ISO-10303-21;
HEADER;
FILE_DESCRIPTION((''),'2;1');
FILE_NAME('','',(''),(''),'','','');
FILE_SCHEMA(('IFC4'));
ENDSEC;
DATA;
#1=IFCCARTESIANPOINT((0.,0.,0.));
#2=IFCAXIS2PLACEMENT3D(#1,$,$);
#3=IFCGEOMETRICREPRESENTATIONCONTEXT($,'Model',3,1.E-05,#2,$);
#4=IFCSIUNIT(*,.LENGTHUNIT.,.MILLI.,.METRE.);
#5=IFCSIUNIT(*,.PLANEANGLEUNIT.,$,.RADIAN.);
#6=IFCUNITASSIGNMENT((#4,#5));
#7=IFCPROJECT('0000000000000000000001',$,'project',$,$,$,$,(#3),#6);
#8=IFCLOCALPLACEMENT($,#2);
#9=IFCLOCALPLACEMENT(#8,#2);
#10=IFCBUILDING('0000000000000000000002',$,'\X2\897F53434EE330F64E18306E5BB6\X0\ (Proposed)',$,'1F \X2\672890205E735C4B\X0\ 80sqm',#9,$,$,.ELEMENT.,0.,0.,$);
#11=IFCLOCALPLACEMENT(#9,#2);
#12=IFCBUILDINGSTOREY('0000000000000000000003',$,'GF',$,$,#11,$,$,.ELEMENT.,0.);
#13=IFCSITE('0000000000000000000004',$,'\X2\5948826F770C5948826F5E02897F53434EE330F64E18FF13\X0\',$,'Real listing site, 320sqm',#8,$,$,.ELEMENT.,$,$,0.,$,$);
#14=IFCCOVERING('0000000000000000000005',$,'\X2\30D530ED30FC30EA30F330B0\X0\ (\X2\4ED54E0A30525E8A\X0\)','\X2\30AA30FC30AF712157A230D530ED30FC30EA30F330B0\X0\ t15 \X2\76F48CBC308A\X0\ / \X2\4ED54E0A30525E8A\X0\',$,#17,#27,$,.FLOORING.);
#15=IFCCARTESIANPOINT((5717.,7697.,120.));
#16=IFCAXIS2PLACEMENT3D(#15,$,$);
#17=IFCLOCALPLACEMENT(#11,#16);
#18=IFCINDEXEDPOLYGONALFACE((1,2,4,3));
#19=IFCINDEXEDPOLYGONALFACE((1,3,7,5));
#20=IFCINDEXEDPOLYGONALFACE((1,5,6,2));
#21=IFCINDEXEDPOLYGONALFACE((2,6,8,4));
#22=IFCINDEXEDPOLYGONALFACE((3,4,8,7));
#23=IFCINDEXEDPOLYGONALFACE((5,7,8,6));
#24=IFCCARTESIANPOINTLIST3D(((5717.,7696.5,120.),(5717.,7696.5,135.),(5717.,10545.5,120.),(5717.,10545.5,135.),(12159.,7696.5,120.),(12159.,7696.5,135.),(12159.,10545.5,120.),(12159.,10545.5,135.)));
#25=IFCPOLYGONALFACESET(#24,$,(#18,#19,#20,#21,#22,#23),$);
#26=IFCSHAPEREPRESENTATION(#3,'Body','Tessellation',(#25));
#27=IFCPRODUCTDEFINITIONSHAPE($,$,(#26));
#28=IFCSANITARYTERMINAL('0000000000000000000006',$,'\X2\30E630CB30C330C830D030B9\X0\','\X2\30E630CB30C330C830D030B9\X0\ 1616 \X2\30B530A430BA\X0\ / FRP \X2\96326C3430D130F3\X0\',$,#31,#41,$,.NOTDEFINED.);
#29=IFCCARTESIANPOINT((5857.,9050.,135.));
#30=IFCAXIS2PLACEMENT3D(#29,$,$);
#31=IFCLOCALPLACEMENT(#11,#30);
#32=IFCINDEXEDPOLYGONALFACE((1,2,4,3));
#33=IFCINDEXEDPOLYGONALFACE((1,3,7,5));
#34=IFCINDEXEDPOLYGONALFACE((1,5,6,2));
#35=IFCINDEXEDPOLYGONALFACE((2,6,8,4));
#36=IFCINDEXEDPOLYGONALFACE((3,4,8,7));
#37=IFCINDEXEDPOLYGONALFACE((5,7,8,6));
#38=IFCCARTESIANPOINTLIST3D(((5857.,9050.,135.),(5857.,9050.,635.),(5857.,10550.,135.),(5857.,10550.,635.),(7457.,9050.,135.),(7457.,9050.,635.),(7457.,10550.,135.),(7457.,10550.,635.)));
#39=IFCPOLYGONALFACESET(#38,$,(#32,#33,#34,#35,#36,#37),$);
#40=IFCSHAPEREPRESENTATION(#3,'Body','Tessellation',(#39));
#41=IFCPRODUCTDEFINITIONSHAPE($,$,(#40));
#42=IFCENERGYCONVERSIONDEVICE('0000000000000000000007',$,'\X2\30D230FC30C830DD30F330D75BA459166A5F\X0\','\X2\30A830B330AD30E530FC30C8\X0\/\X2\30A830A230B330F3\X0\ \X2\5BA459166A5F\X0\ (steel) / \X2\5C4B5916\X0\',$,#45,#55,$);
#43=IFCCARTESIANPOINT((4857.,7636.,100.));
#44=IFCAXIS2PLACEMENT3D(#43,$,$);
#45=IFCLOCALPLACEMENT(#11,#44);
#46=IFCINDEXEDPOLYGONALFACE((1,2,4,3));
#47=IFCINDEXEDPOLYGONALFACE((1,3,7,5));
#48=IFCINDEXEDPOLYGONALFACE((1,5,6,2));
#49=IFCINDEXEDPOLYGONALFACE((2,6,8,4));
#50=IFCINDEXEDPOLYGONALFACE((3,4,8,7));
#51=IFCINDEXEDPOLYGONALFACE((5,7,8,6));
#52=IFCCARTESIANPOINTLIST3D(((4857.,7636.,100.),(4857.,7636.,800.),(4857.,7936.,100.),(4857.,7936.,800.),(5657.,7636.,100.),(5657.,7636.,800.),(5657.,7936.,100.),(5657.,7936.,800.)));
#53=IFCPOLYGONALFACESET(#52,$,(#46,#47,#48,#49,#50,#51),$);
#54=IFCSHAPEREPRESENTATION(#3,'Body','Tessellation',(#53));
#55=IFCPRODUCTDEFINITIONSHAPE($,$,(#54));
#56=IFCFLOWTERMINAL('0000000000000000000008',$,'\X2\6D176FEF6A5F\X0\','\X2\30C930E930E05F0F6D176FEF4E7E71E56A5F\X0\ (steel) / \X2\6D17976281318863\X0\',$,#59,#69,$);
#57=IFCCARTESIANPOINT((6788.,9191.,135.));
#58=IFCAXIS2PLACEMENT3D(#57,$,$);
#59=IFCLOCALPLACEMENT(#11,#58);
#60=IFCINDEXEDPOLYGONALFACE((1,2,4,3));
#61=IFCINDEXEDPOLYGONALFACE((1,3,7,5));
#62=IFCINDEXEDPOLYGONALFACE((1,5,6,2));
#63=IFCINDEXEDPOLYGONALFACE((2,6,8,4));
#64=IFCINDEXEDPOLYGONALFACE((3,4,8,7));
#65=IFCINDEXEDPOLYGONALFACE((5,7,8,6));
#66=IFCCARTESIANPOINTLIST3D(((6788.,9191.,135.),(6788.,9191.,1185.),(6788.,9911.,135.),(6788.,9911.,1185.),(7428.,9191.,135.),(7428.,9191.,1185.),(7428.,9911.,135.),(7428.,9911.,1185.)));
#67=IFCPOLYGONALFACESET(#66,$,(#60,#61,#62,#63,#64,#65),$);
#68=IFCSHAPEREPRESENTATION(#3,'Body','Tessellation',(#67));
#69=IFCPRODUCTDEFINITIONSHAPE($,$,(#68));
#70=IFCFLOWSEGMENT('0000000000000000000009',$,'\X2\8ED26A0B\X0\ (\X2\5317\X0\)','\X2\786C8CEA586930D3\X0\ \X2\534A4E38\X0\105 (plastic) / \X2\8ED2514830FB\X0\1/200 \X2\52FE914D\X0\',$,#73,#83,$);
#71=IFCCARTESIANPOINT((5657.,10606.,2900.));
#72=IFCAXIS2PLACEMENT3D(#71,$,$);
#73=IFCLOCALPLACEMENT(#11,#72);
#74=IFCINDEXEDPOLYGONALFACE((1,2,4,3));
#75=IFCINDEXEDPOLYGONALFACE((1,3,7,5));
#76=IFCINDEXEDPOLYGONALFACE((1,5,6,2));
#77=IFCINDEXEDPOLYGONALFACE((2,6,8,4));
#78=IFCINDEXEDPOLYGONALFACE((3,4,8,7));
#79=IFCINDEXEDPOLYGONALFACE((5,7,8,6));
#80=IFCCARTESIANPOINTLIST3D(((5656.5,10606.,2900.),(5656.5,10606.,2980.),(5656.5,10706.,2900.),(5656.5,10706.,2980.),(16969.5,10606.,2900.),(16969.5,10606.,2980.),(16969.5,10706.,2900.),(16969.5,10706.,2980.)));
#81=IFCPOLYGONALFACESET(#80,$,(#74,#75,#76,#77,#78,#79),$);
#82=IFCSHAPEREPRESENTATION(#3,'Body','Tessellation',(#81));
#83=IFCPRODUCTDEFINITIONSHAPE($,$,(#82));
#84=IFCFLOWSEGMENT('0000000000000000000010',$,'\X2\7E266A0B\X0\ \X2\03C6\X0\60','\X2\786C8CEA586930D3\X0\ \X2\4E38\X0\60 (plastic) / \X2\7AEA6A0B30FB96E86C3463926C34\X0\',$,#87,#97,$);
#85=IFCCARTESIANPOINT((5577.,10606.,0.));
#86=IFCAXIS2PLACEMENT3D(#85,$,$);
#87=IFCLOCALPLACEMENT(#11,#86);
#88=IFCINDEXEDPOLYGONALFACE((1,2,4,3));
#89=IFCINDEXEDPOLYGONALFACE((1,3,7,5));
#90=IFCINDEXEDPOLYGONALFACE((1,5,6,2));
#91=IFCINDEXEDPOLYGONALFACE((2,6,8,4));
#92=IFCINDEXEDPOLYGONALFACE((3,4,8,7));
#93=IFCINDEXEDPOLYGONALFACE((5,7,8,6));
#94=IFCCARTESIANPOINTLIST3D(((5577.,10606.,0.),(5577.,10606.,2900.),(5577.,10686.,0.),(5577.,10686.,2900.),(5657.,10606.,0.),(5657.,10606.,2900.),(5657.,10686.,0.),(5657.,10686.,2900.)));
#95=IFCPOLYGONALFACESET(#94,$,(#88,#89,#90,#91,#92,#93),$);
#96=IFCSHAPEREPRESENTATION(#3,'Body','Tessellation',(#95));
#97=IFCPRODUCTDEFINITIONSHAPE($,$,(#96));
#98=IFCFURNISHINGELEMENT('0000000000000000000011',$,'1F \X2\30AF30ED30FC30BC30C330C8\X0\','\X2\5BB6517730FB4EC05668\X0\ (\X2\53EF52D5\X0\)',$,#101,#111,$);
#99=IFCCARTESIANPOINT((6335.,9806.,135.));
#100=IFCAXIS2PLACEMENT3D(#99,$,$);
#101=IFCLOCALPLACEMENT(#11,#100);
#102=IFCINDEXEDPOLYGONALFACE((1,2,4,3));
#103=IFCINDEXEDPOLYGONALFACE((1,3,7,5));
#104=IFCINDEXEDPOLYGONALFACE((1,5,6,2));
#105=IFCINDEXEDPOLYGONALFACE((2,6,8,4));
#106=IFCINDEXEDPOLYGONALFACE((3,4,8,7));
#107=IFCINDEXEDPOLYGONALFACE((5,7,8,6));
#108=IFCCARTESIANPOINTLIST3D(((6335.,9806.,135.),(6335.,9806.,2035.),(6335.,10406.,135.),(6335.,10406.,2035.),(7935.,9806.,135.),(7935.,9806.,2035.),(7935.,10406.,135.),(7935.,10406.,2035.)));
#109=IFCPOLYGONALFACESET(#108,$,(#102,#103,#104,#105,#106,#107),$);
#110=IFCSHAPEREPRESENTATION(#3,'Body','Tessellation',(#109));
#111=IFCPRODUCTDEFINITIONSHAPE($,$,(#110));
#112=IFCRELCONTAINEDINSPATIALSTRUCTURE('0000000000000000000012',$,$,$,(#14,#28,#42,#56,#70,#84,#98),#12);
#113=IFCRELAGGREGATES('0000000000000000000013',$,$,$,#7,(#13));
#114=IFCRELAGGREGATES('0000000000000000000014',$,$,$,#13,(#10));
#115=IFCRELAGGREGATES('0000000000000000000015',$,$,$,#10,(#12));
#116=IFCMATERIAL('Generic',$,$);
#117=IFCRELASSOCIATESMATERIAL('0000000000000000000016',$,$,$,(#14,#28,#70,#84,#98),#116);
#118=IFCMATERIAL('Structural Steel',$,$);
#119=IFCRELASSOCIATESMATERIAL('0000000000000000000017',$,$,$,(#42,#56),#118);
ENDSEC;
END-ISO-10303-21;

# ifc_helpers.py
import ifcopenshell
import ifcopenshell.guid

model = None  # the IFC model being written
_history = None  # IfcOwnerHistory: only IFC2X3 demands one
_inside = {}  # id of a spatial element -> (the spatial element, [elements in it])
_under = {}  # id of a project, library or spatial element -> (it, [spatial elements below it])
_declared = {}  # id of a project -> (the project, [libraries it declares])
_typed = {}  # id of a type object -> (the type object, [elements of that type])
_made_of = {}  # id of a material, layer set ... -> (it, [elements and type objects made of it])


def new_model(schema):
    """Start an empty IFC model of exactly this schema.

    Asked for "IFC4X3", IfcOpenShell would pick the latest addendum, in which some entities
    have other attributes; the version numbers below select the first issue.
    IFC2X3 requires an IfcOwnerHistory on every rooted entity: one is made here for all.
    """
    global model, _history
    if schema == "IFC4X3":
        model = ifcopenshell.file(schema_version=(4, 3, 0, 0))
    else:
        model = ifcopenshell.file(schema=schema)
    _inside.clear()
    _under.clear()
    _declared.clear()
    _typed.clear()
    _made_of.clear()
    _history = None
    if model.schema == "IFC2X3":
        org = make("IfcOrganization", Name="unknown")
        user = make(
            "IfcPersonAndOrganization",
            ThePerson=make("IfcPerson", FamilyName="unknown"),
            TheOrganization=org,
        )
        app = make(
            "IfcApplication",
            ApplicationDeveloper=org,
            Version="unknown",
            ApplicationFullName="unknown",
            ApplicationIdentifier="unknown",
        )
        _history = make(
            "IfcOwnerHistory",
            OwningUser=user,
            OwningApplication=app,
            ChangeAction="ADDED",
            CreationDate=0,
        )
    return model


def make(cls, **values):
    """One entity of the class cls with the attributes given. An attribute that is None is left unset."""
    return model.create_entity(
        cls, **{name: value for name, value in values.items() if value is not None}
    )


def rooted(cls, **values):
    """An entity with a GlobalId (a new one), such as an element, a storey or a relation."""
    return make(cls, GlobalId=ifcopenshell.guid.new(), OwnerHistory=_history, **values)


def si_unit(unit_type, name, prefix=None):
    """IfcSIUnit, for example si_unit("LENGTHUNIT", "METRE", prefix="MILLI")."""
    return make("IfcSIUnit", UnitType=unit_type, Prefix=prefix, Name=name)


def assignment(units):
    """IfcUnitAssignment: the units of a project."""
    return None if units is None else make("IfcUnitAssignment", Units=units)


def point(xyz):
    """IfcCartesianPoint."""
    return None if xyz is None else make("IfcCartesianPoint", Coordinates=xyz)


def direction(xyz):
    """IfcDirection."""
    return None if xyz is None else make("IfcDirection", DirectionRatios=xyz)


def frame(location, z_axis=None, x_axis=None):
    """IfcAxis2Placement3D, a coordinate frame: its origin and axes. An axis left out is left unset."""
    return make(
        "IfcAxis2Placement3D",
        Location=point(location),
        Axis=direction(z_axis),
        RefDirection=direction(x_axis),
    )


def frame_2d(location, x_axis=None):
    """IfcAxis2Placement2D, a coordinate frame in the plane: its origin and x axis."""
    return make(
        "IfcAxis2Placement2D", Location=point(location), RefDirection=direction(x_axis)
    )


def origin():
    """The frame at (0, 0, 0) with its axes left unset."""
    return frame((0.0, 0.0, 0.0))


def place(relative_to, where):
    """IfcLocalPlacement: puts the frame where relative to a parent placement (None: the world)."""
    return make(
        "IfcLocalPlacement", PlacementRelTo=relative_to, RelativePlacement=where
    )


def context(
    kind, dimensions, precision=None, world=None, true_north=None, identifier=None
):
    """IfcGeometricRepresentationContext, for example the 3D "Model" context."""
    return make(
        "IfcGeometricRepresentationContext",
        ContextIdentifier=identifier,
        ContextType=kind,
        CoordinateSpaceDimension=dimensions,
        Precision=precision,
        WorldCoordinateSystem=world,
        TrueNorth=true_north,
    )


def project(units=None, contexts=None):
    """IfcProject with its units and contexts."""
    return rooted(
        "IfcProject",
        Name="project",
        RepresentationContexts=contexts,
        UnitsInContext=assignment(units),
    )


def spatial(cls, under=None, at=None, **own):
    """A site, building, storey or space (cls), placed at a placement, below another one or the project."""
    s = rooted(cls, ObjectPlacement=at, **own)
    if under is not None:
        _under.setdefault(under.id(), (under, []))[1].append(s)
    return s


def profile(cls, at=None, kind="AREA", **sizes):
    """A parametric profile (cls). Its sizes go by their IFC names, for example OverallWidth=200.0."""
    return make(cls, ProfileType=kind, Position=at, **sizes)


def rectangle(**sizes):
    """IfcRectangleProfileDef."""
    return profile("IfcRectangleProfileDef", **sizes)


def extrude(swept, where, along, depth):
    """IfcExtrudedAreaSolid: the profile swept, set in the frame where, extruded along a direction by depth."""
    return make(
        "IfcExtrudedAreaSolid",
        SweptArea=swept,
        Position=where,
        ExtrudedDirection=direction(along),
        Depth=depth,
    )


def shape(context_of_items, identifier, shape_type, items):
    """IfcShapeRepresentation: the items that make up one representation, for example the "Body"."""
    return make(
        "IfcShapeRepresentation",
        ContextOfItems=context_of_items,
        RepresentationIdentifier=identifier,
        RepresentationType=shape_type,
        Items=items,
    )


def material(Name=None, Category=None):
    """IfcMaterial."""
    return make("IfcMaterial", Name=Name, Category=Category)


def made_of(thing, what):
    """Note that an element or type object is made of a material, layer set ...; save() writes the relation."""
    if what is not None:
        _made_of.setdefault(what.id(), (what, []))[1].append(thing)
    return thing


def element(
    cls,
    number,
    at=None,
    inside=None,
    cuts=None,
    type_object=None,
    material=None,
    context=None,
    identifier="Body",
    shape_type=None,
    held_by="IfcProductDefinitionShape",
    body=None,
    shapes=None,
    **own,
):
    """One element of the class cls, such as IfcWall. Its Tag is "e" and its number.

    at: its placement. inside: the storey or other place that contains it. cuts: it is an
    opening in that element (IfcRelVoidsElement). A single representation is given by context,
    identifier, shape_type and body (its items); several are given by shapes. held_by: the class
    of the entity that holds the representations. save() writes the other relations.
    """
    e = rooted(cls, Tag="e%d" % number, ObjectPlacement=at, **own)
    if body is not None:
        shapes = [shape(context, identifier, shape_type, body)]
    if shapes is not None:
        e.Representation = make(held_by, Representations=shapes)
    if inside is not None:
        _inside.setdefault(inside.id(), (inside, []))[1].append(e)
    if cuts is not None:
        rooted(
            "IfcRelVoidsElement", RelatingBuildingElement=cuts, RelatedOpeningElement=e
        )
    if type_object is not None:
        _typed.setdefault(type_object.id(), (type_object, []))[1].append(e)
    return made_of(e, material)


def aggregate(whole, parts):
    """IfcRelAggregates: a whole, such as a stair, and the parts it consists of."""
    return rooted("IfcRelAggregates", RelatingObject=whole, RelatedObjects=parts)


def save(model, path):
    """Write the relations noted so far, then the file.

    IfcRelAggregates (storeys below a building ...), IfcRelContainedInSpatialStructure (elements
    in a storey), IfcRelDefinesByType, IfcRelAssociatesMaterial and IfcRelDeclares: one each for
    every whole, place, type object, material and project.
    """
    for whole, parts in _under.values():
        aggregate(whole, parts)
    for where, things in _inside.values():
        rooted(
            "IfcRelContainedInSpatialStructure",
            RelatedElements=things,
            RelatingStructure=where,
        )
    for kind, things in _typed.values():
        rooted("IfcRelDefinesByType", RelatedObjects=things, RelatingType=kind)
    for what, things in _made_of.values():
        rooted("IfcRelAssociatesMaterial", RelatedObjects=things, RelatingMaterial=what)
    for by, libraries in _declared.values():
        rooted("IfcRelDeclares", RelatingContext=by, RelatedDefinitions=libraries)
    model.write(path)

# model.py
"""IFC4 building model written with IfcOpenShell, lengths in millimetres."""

from ifc_helpers import new_model, si_unit, frame, frame_2d, origin, place, context, project, spatial, rectangle, extrude, material, element, save


model = new_model("IFC4")

# Units and contexts
model_context = context("Model", 3, precision=1e-05, world=origin())
ifc_project = project(units=[si_unit("LENGTHUNIT", "METRE", prefix="MILLI"), si_unit("PLANEANGLEUNIT", "RADIAN")], contexts=[model_context])

# Site, building, storey
site_placement = place(None, origin())
site = spatial("IfcSite", under=ifc_project, at=site_placement, Name="奈良県奈良市西千代ヶ丘３", ObjectType="Real listing site, 320sqm", CompositionType="ELEMENT", RefElevation=0.0)
building_placement = place(site_placement, origin())
building = spatial("IfcBuilding", under=site, at=building_placement, Name="西千代ヶ丘の家 (Proposed)", ObjectType="1F 木造平屋 80sqm", CompositionType="ELEMENT", ElevationOfRefHeight=0.0, ElevationOfTerrain=0.0)
storey_placement = place(building_placement, origin())
storey = spatial("IfcBuildingStorey", under=building, at=storey_placement, Name="GF", CompositionType="ELEMENT", Elevation=0.0)

# Shared definitions
ifc_material_1 = material(Name="Structural Steel")

# Covering
ifc_material_2 = material(Name="Generic")
covering_placement = place(storey_placement, frame((5717.0, 7697.0, 120.0)))
element("IfcCovering", 1, at=covering_placement, inside=storey, material=ifc_material_2, Name="フローリング (仕上げ床)", Description="オーク無垢フローリング t15 直貼り / 仕上げ床", PredefinedType="FLOORING", context=model_context, shape_type="SweptSolid", body=[
    extrude(rectangle(XDim=6442.0, YDim=2849.0, at=frame_2d((3221.0, 1424.0))), frame((5717.0, 7697.0, 120.0)), (0.0, 0.0, 1.0), 15.0),
])

# Sanitary terminal
sanitary_terminal_placement = place(storey_placement, frame((5857.0, 9050.0, 135.0)))
element("IfcSanitaryTerminal", 2, at=sanitary_terminal_placement, inside=storey, material=ifc_material_2, Name="ユニットバス", Description="ユニットバス 1616 サイズ / FRP 防水パン", PredefinedType="NOTDEFINED", context=model_context, shape_type="SweptSolid", body=[
    extrude(rectangle(XDim=1600.0, YDim=1500.0, at=frame_2d((800.0, 750.0))), frame((5857.0, 9050.0, 135.0)), (0.0, 0.0, 1.0), 500.0),
])

# Energy conversion device
energy_conversion_device_placement = place(storey_placement, frame((4857.0, 7636.0, 100.0)))
element("IfcEnergyConversionDevice", 3, at=energy_conversion_device_placement, inside=storey, material=ifc_material_1, Name="ヒートポンプ室外機", Description="エコキュート/エアコン 室外機 (steel) / 屋外", context=model_context, shape_type="SweptSolid", body=[
    extrude(rectangle(XDim=800.0, YDim=300.0, at=frame_2d((400.0, 150.0))), frame((4857.0, 7636.0, 100.0)), (0.0, 0.0, 1.0), 700.0),
])

# Flow terminal
flow_terminal_placement = place(storey_placement, frame((6788.0, 9191.0, 135.0)))
element("IfcFlowTerminal", 4, at=flow_terminal_placement, inside=storey, material=ifc_material_1, Name="洗濯機", Description="ドラム式洗濯乾燥機 (steel) / 洗面脱衣", context=model_context, shape_type="SweptSolid", body=[
    extrude(rectangle(XDim=640.0, YDim=720.0, at=frame_2d((320.0, 360.0))), frame((6788.0, 9191.0, 135.0)), (0.0, 0.0, 1.0), 1050.0),
])

# Flow segments
flow_segment_1_placement = place(storey_placement, frame((5657.0, 10606.0, 2900.0)))
element("IfcFlowSegment", 5, at=flow_segment_1_placement, inside=storey, material=ifc_material_2, Name="軒樋 (北)", Description="硬質塩ビ 半丸105 (plastic) / 軒先・1/200 勾配", context=model_context, shape_type="SweptSolid", body=[
    extrude(rectangle(XDim=11313.0, YDim=100.0, at=frame_2d((5656.0, 50.0))), frame((5657.0, 10606.0, 2900.0)), (0.0, 0.0, 1.0), 80.0),
])
flow_segment_2_placement = place(storey_placement, frame((5577.0, 10606.0, 0.0)))
element("IfcFlowSegment", 6, at=flow_segment_2_placement, inside=storey, material=ifc_material_2, Name="縦樋 φ60", Description="硬質塩ビ 丸60 (plastic) / 竪樋・雨水排水", context=model_context, shape_type="SweptSolid", body=[
    extrude(rectangle(XDim=80.0, YDim=80.0, at=frame_2d((40.0, 40.0))), frame((5577.0, 10606.0, 0.0)), (0.0, 0.0, 1.0), 2900.0),
])

# Furnishing element
furnishing_placement = place(storey_placement, frame((6335.0, 9806.0, 135.0)))
element("IfcFurnishingElement", 7, at=furnishing_placement, inside=storey, material=ifc_material_2, Name="1F クローゼット", Description="家具・什器 (可動)", context=model_context, shape_type="SweptSolid", body=[
    extrude(rectangle(XDim=1600.0, YDim=600.0, at=frame_2d((800.0, 300.0))), frame((6335.0, 9806.0, 135.0)), (0.0, 0.0, 1.0), 1900.0),
])

save(model, "model.ifc")
